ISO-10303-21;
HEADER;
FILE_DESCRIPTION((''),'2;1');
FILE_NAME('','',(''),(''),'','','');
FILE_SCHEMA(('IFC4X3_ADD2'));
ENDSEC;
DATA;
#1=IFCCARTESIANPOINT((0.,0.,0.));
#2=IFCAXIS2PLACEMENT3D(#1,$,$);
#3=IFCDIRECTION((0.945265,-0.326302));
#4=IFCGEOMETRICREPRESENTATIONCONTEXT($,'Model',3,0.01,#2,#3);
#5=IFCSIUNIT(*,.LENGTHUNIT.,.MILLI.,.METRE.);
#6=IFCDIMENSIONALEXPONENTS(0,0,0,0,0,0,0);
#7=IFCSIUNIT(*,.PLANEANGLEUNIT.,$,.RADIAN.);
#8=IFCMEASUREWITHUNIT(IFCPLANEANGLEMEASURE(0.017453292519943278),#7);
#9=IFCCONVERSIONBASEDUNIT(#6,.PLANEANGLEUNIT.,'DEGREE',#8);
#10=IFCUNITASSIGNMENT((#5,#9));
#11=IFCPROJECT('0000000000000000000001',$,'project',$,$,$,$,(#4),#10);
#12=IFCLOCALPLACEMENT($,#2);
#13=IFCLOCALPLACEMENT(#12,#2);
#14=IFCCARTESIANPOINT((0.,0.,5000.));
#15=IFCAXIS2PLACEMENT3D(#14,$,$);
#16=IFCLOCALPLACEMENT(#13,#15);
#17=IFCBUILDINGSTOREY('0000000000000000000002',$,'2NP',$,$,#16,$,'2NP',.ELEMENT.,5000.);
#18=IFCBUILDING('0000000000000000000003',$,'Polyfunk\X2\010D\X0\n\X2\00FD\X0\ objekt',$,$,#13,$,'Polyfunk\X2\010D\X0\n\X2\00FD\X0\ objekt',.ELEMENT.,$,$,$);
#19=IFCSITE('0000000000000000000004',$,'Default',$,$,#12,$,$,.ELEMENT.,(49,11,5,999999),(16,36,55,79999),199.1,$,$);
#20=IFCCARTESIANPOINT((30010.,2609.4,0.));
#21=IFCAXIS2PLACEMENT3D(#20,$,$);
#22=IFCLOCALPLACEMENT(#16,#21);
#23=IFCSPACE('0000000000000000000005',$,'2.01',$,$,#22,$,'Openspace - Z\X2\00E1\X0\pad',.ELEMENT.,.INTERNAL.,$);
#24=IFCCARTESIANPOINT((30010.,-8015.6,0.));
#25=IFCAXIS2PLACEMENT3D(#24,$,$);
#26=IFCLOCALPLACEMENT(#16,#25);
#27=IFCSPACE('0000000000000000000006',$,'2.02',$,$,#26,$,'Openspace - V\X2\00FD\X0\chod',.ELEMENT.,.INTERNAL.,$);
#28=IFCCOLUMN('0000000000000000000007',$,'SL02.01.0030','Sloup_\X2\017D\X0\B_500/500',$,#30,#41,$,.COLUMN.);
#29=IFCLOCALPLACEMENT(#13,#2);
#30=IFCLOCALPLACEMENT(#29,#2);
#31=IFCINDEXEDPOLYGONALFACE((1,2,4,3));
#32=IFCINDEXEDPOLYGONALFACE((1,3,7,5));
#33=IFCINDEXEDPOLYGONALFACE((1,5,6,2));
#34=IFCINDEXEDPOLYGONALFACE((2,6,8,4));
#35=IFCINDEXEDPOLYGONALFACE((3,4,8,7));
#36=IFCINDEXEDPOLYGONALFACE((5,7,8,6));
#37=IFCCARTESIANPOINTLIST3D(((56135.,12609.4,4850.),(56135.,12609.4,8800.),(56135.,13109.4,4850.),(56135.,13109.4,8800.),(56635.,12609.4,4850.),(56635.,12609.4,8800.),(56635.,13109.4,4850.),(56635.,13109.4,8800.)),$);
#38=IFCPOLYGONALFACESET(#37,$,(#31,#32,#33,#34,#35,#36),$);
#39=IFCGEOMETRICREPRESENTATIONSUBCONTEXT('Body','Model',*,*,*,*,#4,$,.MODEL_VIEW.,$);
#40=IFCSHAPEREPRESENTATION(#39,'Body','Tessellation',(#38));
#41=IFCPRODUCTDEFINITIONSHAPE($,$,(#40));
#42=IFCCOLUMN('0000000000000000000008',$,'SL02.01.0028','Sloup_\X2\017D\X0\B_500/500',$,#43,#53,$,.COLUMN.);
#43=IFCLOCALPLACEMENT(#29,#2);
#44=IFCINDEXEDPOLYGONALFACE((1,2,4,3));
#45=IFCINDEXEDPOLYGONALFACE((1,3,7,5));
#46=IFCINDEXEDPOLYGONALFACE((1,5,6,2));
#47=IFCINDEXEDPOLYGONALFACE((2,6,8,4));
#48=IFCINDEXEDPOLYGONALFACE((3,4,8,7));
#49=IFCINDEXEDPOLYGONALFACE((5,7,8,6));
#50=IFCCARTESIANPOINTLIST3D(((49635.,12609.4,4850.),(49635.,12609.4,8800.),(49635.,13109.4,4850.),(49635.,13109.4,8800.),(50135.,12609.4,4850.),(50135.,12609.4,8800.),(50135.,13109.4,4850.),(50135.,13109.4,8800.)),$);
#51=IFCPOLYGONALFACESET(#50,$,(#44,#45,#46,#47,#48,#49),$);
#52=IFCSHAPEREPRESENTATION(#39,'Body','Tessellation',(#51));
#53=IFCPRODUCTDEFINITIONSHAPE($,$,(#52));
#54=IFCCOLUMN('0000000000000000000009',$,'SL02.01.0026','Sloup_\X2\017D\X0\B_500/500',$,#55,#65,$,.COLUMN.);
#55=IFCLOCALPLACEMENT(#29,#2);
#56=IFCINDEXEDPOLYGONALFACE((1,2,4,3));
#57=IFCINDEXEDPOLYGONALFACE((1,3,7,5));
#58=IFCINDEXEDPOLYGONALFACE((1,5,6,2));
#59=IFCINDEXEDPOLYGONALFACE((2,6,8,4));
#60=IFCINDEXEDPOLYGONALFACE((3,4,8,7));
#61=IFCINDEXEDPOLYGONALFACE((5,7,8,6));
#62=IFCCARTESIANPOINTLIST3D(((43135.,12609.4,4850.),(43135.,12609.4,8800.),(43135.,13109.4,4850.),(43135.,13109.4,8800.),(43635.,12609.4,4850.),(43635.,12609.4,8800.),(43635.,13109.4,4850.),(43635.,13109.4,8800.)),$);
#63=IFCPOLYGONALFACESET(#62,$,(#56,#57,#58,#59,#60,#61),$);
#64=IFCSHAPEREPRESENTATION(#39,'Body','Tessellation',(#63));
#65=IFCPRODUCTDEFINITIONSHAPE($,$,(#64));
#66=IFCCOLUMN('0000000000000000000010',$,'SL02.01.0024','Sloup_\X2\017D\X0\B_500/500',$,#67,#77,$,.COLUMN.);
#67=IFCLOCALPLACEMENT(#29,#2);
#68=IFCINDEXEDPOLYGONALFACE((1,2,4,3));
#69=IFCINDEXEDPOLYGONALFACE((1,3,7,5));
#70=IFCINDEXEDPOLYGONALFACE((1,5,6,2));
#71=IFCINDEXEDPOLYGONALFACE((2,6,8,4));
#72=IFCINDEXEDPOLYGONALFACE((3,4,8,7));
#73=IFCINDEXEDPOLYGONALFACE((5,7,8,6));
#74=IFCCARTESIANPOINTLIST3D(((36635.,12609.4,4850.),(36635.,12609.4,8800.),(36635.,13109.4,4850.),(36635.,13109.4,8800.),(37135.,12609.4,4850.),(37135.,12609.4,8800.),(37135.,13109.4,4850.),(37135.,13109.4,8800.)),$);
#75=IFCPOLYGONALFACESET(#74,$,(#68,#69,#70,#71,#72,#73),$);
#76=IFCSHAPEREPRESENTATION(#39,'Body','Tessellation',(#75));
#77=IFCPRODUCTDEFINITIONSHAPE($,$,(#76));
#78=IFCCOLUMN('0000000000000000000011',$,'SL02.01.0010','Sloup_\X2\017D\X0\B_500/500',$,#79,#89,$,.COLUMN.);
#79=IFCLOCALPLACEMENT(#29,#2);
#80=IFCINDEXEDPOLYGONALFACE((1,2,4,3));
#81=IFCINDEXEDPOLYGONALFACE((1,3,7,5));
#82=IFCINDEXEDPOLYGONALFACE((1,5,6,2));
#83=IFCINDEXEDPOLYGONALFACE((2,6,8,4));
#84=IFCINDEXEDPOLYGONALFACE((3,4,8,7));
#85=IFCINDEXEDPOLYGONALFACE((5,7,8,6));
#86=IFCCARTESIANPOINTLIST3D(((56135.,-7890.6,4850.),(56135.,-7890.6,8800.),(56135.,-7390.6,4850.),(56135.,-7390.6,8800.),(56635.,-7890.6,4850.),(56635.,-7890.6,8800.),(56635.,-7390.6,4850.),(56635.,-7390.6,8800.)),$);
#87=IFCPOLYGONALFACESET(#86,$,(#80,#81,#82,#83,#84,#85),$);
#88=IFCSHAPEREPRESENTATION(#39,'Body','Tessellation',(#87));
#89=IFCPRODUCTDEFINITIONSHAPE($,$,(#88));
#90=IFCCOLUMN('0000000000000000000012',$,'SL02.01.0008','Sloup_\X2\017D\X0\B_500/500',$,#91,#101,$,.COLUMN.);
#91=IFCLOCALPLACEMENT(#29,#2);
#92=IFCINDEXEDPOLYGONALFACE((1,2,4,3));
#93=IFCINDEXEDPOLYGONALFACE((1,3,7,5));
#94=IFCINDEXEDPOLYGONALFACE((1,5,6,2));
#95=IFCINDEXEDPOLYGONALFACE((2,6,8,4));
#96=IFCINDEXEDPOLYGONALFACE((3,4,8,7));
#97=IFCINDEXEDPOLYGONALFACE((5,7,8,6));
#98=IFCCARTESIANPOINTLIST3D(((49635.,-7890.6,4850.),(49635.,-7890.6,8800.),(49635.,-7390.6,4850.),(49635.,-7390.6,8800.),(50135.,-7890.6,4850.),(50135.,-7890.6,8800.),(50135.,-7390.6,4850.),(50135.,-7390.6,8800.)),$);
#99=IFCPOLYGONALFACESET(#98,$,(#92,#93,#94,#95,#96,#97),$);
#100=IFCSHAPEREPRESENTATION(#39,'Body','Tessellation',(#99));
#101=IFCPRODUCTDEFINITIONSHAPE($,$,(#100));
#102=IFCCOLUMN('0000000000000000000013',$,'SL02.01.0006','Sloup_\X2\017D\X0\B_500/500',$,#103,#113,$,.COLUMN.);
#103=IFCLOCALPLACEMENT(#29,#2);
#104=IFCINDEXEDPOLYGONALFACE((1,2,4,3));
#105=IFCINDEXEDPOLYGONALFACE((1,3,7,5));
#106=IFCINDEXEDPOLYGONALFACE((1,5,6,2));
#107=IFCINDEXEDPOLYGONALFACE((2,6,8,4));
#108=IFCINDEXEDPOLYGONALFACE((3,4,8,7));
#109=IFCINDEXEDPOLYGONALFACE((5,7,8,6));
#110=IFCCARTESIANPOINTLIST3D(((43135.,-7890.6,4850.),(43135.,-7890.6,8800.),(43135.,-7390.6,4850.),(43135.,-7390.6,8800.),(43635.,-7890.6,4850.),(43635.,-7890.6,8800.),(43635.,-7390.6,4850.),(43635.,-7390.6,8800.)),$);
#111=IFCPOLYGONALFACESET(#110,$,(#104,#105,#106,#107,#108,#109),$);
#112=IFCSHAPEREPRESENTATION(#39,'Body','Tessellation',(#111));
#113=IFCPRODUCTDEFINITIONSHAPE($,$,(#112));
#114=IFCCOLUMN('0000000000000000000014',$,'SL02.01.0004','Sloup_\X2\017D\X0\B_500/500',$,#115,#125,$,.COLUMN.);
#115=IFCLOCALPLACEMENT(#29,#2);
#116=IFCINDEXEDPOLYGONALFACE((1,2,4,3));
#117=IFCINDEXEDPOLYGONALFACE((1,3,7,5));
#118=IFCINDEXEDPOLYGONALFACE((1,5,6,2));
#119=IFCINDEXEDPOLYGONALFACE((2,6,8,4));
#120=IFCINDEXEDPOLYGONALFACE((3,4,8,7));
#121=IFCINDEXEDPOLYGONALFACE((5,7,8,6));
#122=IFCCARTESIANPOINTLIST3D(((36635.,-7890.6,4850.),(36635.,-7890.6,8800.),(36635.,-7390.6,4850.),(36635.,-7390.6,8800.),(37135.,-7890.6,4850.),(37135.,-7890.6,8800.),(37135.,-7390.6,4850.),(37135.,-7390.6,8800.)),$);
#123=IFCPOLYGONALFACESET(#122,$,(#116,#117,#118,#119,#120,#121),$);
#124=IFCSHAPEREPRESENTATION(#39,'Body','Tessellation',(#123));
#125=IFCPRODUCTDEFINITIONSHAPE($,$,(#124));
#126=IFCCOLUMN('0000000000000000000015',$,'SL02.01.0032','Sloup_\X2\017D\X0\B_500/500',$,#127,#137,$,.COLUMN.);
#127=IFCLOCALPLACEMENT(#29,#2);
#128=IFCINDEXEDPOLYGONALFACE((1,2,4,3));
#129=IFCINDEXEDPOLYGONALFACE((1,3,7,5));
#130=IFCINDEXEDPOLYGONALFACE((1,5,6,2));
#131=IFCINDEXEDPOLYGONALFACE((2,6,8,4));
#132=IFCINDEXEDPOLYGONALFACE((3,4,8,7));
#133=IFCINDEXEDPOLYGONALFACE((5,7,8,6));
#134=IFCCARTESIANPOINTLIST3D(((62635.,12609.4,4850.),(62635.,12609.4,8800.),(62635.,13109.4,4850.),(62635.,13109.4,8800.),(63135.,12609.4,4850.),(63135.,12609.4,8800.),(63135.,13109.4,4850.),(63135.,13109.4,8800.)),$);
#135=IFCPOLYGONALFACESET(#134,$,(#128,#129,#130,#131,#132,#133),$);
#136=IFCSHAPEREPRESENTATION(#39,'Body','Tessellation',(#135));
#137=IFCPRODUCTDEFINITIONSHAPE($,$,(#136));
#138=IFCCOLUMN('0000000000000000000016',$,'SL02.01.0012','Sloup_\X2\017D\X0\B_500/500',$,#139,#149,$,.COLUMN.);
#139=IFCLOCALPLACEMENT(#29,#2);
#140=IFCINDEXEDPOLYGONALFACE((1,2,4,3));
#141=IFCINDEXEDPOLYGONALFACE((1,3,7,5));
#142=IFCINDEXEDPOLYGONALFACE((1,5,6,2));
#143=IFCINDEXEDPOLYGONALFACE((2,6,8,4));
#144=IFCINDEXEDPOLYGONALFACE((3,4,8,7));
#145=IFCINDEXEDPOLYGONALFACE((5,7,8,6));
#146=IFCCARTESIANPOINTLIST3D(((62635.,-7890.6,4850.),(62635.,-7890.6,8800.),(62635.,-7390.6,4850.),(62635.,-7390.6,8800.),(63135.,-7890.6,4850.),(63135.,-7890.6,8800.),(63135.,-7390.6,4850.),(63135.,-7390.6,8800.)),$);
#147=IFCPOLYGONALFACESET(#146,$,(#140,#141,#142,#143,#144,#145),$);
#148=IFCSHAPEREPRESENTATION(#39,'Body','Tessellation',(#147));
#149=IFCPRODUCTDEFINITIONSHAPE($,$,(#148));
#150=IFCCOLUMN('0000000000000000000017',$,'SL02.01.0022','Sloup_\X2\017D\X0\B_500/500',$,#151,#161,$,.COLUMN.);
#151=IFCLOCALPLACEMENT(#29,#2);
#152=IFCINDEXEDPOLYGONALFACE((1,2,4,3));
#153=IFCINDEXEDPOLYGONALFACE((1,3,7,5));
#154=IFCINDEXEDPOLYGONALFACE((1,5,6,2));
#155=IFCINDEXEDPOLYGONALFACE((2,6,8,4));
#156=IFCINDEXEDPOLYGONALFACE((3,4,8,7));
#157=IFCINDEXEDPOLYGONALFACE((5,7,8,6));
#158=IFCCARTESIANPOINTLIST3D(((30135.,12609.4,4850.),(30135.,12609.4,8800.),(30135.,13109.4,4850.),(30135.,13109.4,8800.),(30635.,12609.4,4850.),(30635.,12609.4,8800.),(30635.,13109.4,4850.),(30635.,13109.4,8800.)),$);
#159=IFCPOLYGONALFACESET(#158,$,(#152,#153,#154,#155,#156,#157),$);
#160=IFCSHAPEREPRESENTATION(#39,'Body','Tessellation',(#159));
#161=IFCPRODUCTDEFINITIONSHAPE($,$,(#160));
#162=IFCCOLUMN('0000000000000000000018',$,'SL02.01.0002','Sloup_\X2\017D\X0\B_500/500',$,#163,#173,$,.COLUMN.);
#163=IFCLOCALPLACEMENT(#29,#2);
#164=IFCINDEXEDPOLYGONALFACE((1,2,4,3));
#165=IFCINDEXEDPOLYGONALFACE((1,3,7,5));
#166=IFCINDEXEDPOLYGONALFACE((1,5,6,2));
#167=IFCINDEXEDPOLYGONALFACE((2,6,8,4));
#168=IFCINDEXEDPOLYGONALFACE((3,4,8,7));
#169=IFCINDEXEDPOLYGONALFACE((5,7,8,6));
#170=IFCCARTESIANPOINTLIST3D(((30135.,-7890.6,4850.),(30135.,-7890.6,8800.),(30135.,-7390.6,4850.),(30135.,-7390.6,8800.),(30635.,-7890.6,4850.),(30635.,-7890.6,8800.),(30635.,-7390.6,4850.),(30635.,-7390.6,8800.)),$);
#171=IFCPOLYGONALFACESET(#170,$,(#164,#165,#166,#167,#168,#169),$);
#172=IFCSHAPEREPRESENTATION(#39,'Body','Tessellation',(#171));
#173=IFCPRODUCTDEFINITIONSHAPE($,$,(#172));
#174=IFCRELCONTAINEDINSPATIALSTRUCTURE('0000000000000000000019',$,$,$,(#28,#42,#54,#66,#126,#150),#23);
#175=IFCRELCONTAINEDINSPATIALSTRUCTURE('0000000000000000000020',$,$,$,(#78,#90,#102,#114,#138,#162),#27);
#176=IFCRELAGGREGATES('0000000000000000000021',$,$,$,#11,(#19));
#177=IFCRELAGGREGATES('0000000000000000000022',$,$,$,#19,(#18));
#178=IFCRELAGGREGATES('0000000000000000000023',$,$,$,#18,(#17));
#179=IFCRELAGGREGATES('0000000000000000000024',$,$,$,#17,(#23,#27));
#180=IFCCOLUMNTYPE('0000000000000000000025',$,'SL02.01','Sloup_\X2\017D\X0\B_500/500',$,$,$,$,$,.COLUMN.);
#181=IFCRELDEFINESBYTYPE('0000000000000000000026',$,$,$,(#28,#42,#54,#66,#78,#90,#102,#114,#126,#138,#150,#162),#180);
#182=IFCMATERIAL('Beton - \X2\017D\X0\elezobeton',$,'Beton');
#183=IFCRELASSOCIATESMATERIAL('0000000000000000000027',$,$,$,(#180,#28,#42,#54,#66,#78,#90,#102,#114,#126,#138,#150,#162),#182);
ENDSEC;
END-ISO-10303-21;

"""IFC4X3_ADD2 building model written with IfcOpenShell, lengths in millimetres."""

from ifc_helpers import new_model, entity, si_unit, converted_unit, direction, frame, frame_2d, origin, origin_2d_with_axis, place, context, subcontext, project, spatial, rectangle, extrude, source, transform, mapped, material, material_profile, profile_set, profile_usage, type_object, element, save


model = new_model("IFC4X3_ADD2")

# Units and contexts
model_context = context("Model", 3, precision=0.01, world=origin(), true_north=direction((0.945265, -0.326302)))
body_context = subcontext(model_context, "Body", "Model", "MODEL_VIEW")
ifc_project = project(units=[si_unit("LENGTHUNIT", "METRE", prefix="MILLI"), converted_unit("PLANEANGLEUNIT", "DEGREE", entity("IfcPlaneAngleMeasure", 0.017453292519943278), si_unit("PLANEANGLEUNIT", "RADIAN"), dimensions=[0, 0, 0, 0, 0, 0, 0])], contexts=[model_context])

# Site, building, storey, space
site_placement = place(None, origin())
site = spatial("IfcSite", under=ifc_project, at=site_placement, Name="Default", CompositionType="ELEMENT", RefLatitude=(49, 11, 5, 999999), RefLongitude=(16, 36, 55, 79999), RefElevation=199.1)
building_placement = place(site_placement, origin())
building = spatial("IfcBuilding", under=site, at=building_placement, Name="Polyfunkčný objekt", LongName="Polyfunkčný objekt", CompositionType="ELEMENT")
storey_placement = place(building_placement, frame((0.0, 0.0, 5000.0)))
storey = spatial("IfcBuildingStorey", under=building, at=storey_placement, Name="2NP", LongName="2NP", CompositionType="ELEMENT", Elevation=5000.0)
space_1_placement = place(storey_placement, frame((30010.0, 2609.4, 0.0)))
space_1 = spatial("IfcSpace", under=storey, at=space_1_placement, Name="2.01", LongName="Openspace - Západ", CompositionType="ELEMENT", PredefinedType="INTERNAL")

# Columns
ifc_material_1 = material(Name="Beton - Železobeton", Category="Beton")
ifc_material_profile_1 = material_profile(ifc_material_1, rectangle(XDim=500.0, YDim=500.0, at=frame_2d((0.0, 0.0), x_axis=(1.0, 0.0))), Name="Sloup_ŽB_500/500")
ifc_profile_set_1 = profile_set([ifc_material_profile_1], Name="Sloup_ŽB_500/500")
ifc_profile_usage_1 = profile_usage(ifc_profile_set_1)
column_type_1 = type_object("IfcColumnType", Name="SL02.01", Description="Sloup_ŽB_500/500", PredefinedType="COLUMN", material=ifc_profile_set_1)
shared_shape_1 = source(origin(), body_context, "Body", "SweptSolid", [
    extrude(rectangle(XDim=500.0, YDim=500.0, at=frame_2d((0.0, 0.0), x_axis=(1.0, 0.0))), frame((56385.0, 12859.4, 4850.0)), (0.0, 0.0, 1.0), 3950.0),
])
placement = place(building_placement, origin())
column_1_placement = place(placement, origin())
element("IfcColumn", 1, at=column_1_placement, inside=space_1, type_object=column_type_1, material=ifc_profile_usage_1, Name="SL02.01.0030", Description="Sloup_ŽB_500/500", PredefinedType="COLUMN", context=body_context, shape_type="MappedRepresentation", body=[
    mapped(shared_shape_1, transform((0.0, 0.0, 0.0), scale=1.0)),
])
shared_shape_2 = source(origin(), body_context, "Body", "SweptSolid", [
    extrude(rectangle(XDim=500.0, YDim=500.0, at=origin_2d_with_axis()), frame((49885.0, 12859.4, 4850.0)), (0.0, 0.0, 1.0), 3950.0),
])
column_2_placement = place(placement, origin())
element("IfcColumn", 2, at=column_2_placement, inside=space_1, type_object=column_type_1, material=ifc_profile_usage_1, Name="SL02.01.0028", Description="Sloup_ŽB_500/500", PredefinedType="COLUMN", context=body_context, shape_type="MappedRepresentation", body=[
    mapped(shared_shape_2, transform((0.0, 0.0, 0.0), scale=1.0)),
])
shared_shape_3 = source(origin(), body_context, "Body", "SweptSolid", [
    extrude(rectangle(XDim=500.0, YDim=500.0, at=origin_2d_with_axis()), frame((43385.0, 12859.4, 4850.0)), (0.0, 0.0, 1.0), 3950.0),
])
column_3_placement = place(placement, origin())
element("IfcColumn", 3, at=column_3_placement, inside=space_1, type_object=column_type_1, material=ifc_profile_usage_1, Name="SL02.01.0026", Description="Sloup_ŽB_500/500", PredefinedType="COLUMN", context=body_context, shape_type="MappedRepresentation", body=[
    mapped(shared_shape_3, transform((0.0, 0.0, 0.0), scale=1.0)),
])
shared_shape_4 = source(origin(), body_context, "Body", "SweptSolid", [
    extrude(rectangle(XDim=500.0, YDim=500.0, at=origin_2d_with_axis()), frame((36885.0, 12859.4, 4850.0), z_axis=(0.0, 0.0, 1.0), x_axis=(0.0, 1.0, 0.0)), (0.0, 0.0, 1.0), 3950.0),
])
column_4_placement = place(placement, origin())
element("IfcColumn", 4, at=column_4_placement, inside=space_1, type_object=column_type_1, material=ifc_profile_usage_1, Name="SL02.01.0024", Description="Sloup_ŽB_500/500", PredefinedType="COLUMN", context=body_context, shape_type="MappedRepresentation", body=[
    mapped(shared_shape_4, transform((0.0, 0.0, 0.0), scale=1.0)),
])

# Shared definitions
space_2_placement = place(storey_placement, frame((30010.0, -8015.6, 0.0)))
space_2 = spatial("IfcSpace", under=storey, at=space_2_placement, Name="2.02", LongName="Openspace - Východ", CompositionType="ELEMENT", PredefinedType="INTERNAL")

# Columns
shared_shape_5 = source(origin(), body_context, "Body", "SweptSolid", [
    extrude(rectangle(XDim=500.0, YDim=500.0, at=origin_2d_with_axis()), frame((56385.0, -7640.6, 4850.0)), (0.0, 0.0, 1.0), 3950.0),
])
column_5_placement = place(placement, origin())
element("IfcColumn", 5, at=column_5_placement, inside=space_2, type_object=column_type_1, material=ifc_profile_usage_1, Name="SL02.01.0010", Description="Sloup_ŽB_500/500", PredefinedType="COLUMN", context=body_context, shape_type="MappedRepresentation", body=[
    mapped(shared_shape_5, transform((0.0, 0.0, 0.0), scale=1.0)),
])
shared_shape_6 = source(origin(), body_context, "Body", "SweptSolid", [
    extrude(rectangle(XDim=500.0, YDim=500.0, at=frame_2d((0.0, 0.0), x_axis=(1.0, 0.0))), frame((49885.0, -7640.6, 4850.0)), (0.0, 0.0, 1.0), 3950.0),
])
column_6_placement = place(placement, origin())
element("IfcColumn", 6, at=column_6_placement, inside=space_2, type_object=column_type_1, material=ifc_profile_usage_1, Name="SL02.01.0008", Description="Sloup_ŽB_500/500", PredefinedType="COLUMN", context=body_context, shape_type="MappedRepresentation", body=[
    mapped(shared_shape_6, transform((0.0, 0.0, 0.0), scale=1.0)),
])
shared_shape_7 = source(origin(), body_context, "Body", "SweptSolid", [
    extrude(rectangle(XDim=500.0, YDim=500.0, at=origin_2d_with_axis()), frame((43385.0, -7640.6, 4850.0)), (0.0, 0.0, 1.0), 3950.0),
])
column_7_placement = place(placement, origin())
element("IfcColumn", 7, at=column_7_placement, inside=space_2, type_object=column_type_1, material=ifc_profile_usage_1, Name="SL02.01.0006", Description="Sloup_ŽB_500/500", PredefinedType="COLUMN", context=body_context, shape_type="MappedRepresentation", body=[
    mapped(shared_shape_7, transform((0.0, 0.0, 0.0), scale=1.0)),
])
shared_shape_8 = source(origin(), body_context, "Body", "SweptSolid", [
    extrude(rectangle(XDim=500.0, YDim=500.0, at=origin_2d_with_axis()), frame((36885.0, -7640.6, 4850.0)), (0.0, 0.0, 1.0), 3950.0),
])
column_8_placement = place(placement, origin())
element("IfcColumn", 8, at=column_8_placement, inside=space_2, type_object=column_type_1, material=ifc_profile_usage_1, Name="SL02.01.0004", Description="Sloup_ŽB_500/500", PredefinedType="COLUMN", context=body_context, shape_type="MappedRepresentation", body=[
    mapped(shared_shape_8, transform((0.0, 0.0, 0.0), scale=1.0)),
])
shared_shape_9 = source(origin(), body_context, "Body", "SweptSolid", [
    extrude(rectangle(XDim=500.0, YDim=500.0, at=origin_2d_with_axis()), frame((62885.0, 12859.4, 4850.0), z_axis=(0.0, 0.0, 1.0), x_axis=(-1.0, 0.0, 0.0)), (0.0, 0.0, 1.0), 3950.0),
])
column_9_placement = place(placement, origin())
element("IfcColumn", 9, at=column_9_placement, inside=space_1, type_object=column_type_1, material=ifc_profile_usage_1, Name="SL02.01.0032", Description="Sloup_ŽB_500/500", PredefinedType="COLUMN", context=body_context, shape_type="MappedRepresentation", body=[
    mapped(shared_shape_9, transform((0.0, 0.0, 0.0), scale=1.0)),
])
shared_shape_10 = source(origin(), body_context, "Body", "SweptSolid", [
    extrude(rectangle(XDim=500.0, YDim=500.0, at=frame_2d((0.0, 0.0), x_axis=(1.0, 0.0))), frame((62885.0, -7640.6, 4850.0), z_axis=(0.0, 0.0, 1.0), x_axis=(-1.0, 0.0, 0.0)), (0.0, 0.0, 1.0), 3950.0),
])
column_10_placement = place(placement, origin())
element("IfcColumn", 10, at=column_10_placement, inside=space_2, type_object=column_type_1, material=ifc_profile_usage_1, Name="SL02.01.0012", Description="Sloup_ŽB_500/500", PredefinedType="COLUMN", context=body_context, shape_type="MappedRepresentation", body=[
    mapped(shared_shape_10, transform((0.0, 0.0, 0.0), scale=1.0)),
])
shared_shape_11 = source(origin(), body_context, "Body", "SweptSolid", [
    extrude(rectangle(XDim=500.0, YDim=500.0, at=origin_2d_with_axis()), frame((30385.0, 12859.4, 4850.0), z_axis=(0.0, 0.0, 1.0), x_axis=(-1.0, 0.0, 0.0)), (0.0, 0.0, 1.0), 3950.0),
])
column_11_placement = place(placement, origin())
element("IfcColumn", 11, at=column_11_placement, inside=space_1, type_object=column_type_1, material=ifc_profile_usage_1, Name="SL02.01.0022", Description="Sloup_ŽB_500/500", PredefinedType="COLUMN", context=body_context, shape_type="MappedRepresentation", body=[
    mapped(shared_shape_11, transform((0.0, 0.0, 0.0), scale=1.0)),
])
shared_shape_12 = source(origin(), body_context, "Body", "SweptSolid", [
    extrude(rectangle(XDim=500.0, YDim=500.0, at=frame_2d((0.0, 0.0), x_axis=(1.0, 0.0))), frame((30385.0, -7640.6, 4850.0), z_axis=(0.0, 0.0, 1.0), x_axis=(-1.0, 0.0, 0.0)), (0.0, 0.0, 1.0), 3950.0),
])
column_12_placement = place(placement, origin())
element("IfcColumn", 12, at=column_12_placement, inside=space_2, type_object=column_type_1, material=ifc_profile_usage_1, Name="SL02.01.0002", Description="Sloup_ŽB_500/500", PredefinedType="COLUMN", context=body_context, shape_type="MappedRepresentation", body=[
    mapped(shared_shape_12, transform((0.0, 0.0, 0.0), scale=1.0)),
])

save(model, "model.ifc")
